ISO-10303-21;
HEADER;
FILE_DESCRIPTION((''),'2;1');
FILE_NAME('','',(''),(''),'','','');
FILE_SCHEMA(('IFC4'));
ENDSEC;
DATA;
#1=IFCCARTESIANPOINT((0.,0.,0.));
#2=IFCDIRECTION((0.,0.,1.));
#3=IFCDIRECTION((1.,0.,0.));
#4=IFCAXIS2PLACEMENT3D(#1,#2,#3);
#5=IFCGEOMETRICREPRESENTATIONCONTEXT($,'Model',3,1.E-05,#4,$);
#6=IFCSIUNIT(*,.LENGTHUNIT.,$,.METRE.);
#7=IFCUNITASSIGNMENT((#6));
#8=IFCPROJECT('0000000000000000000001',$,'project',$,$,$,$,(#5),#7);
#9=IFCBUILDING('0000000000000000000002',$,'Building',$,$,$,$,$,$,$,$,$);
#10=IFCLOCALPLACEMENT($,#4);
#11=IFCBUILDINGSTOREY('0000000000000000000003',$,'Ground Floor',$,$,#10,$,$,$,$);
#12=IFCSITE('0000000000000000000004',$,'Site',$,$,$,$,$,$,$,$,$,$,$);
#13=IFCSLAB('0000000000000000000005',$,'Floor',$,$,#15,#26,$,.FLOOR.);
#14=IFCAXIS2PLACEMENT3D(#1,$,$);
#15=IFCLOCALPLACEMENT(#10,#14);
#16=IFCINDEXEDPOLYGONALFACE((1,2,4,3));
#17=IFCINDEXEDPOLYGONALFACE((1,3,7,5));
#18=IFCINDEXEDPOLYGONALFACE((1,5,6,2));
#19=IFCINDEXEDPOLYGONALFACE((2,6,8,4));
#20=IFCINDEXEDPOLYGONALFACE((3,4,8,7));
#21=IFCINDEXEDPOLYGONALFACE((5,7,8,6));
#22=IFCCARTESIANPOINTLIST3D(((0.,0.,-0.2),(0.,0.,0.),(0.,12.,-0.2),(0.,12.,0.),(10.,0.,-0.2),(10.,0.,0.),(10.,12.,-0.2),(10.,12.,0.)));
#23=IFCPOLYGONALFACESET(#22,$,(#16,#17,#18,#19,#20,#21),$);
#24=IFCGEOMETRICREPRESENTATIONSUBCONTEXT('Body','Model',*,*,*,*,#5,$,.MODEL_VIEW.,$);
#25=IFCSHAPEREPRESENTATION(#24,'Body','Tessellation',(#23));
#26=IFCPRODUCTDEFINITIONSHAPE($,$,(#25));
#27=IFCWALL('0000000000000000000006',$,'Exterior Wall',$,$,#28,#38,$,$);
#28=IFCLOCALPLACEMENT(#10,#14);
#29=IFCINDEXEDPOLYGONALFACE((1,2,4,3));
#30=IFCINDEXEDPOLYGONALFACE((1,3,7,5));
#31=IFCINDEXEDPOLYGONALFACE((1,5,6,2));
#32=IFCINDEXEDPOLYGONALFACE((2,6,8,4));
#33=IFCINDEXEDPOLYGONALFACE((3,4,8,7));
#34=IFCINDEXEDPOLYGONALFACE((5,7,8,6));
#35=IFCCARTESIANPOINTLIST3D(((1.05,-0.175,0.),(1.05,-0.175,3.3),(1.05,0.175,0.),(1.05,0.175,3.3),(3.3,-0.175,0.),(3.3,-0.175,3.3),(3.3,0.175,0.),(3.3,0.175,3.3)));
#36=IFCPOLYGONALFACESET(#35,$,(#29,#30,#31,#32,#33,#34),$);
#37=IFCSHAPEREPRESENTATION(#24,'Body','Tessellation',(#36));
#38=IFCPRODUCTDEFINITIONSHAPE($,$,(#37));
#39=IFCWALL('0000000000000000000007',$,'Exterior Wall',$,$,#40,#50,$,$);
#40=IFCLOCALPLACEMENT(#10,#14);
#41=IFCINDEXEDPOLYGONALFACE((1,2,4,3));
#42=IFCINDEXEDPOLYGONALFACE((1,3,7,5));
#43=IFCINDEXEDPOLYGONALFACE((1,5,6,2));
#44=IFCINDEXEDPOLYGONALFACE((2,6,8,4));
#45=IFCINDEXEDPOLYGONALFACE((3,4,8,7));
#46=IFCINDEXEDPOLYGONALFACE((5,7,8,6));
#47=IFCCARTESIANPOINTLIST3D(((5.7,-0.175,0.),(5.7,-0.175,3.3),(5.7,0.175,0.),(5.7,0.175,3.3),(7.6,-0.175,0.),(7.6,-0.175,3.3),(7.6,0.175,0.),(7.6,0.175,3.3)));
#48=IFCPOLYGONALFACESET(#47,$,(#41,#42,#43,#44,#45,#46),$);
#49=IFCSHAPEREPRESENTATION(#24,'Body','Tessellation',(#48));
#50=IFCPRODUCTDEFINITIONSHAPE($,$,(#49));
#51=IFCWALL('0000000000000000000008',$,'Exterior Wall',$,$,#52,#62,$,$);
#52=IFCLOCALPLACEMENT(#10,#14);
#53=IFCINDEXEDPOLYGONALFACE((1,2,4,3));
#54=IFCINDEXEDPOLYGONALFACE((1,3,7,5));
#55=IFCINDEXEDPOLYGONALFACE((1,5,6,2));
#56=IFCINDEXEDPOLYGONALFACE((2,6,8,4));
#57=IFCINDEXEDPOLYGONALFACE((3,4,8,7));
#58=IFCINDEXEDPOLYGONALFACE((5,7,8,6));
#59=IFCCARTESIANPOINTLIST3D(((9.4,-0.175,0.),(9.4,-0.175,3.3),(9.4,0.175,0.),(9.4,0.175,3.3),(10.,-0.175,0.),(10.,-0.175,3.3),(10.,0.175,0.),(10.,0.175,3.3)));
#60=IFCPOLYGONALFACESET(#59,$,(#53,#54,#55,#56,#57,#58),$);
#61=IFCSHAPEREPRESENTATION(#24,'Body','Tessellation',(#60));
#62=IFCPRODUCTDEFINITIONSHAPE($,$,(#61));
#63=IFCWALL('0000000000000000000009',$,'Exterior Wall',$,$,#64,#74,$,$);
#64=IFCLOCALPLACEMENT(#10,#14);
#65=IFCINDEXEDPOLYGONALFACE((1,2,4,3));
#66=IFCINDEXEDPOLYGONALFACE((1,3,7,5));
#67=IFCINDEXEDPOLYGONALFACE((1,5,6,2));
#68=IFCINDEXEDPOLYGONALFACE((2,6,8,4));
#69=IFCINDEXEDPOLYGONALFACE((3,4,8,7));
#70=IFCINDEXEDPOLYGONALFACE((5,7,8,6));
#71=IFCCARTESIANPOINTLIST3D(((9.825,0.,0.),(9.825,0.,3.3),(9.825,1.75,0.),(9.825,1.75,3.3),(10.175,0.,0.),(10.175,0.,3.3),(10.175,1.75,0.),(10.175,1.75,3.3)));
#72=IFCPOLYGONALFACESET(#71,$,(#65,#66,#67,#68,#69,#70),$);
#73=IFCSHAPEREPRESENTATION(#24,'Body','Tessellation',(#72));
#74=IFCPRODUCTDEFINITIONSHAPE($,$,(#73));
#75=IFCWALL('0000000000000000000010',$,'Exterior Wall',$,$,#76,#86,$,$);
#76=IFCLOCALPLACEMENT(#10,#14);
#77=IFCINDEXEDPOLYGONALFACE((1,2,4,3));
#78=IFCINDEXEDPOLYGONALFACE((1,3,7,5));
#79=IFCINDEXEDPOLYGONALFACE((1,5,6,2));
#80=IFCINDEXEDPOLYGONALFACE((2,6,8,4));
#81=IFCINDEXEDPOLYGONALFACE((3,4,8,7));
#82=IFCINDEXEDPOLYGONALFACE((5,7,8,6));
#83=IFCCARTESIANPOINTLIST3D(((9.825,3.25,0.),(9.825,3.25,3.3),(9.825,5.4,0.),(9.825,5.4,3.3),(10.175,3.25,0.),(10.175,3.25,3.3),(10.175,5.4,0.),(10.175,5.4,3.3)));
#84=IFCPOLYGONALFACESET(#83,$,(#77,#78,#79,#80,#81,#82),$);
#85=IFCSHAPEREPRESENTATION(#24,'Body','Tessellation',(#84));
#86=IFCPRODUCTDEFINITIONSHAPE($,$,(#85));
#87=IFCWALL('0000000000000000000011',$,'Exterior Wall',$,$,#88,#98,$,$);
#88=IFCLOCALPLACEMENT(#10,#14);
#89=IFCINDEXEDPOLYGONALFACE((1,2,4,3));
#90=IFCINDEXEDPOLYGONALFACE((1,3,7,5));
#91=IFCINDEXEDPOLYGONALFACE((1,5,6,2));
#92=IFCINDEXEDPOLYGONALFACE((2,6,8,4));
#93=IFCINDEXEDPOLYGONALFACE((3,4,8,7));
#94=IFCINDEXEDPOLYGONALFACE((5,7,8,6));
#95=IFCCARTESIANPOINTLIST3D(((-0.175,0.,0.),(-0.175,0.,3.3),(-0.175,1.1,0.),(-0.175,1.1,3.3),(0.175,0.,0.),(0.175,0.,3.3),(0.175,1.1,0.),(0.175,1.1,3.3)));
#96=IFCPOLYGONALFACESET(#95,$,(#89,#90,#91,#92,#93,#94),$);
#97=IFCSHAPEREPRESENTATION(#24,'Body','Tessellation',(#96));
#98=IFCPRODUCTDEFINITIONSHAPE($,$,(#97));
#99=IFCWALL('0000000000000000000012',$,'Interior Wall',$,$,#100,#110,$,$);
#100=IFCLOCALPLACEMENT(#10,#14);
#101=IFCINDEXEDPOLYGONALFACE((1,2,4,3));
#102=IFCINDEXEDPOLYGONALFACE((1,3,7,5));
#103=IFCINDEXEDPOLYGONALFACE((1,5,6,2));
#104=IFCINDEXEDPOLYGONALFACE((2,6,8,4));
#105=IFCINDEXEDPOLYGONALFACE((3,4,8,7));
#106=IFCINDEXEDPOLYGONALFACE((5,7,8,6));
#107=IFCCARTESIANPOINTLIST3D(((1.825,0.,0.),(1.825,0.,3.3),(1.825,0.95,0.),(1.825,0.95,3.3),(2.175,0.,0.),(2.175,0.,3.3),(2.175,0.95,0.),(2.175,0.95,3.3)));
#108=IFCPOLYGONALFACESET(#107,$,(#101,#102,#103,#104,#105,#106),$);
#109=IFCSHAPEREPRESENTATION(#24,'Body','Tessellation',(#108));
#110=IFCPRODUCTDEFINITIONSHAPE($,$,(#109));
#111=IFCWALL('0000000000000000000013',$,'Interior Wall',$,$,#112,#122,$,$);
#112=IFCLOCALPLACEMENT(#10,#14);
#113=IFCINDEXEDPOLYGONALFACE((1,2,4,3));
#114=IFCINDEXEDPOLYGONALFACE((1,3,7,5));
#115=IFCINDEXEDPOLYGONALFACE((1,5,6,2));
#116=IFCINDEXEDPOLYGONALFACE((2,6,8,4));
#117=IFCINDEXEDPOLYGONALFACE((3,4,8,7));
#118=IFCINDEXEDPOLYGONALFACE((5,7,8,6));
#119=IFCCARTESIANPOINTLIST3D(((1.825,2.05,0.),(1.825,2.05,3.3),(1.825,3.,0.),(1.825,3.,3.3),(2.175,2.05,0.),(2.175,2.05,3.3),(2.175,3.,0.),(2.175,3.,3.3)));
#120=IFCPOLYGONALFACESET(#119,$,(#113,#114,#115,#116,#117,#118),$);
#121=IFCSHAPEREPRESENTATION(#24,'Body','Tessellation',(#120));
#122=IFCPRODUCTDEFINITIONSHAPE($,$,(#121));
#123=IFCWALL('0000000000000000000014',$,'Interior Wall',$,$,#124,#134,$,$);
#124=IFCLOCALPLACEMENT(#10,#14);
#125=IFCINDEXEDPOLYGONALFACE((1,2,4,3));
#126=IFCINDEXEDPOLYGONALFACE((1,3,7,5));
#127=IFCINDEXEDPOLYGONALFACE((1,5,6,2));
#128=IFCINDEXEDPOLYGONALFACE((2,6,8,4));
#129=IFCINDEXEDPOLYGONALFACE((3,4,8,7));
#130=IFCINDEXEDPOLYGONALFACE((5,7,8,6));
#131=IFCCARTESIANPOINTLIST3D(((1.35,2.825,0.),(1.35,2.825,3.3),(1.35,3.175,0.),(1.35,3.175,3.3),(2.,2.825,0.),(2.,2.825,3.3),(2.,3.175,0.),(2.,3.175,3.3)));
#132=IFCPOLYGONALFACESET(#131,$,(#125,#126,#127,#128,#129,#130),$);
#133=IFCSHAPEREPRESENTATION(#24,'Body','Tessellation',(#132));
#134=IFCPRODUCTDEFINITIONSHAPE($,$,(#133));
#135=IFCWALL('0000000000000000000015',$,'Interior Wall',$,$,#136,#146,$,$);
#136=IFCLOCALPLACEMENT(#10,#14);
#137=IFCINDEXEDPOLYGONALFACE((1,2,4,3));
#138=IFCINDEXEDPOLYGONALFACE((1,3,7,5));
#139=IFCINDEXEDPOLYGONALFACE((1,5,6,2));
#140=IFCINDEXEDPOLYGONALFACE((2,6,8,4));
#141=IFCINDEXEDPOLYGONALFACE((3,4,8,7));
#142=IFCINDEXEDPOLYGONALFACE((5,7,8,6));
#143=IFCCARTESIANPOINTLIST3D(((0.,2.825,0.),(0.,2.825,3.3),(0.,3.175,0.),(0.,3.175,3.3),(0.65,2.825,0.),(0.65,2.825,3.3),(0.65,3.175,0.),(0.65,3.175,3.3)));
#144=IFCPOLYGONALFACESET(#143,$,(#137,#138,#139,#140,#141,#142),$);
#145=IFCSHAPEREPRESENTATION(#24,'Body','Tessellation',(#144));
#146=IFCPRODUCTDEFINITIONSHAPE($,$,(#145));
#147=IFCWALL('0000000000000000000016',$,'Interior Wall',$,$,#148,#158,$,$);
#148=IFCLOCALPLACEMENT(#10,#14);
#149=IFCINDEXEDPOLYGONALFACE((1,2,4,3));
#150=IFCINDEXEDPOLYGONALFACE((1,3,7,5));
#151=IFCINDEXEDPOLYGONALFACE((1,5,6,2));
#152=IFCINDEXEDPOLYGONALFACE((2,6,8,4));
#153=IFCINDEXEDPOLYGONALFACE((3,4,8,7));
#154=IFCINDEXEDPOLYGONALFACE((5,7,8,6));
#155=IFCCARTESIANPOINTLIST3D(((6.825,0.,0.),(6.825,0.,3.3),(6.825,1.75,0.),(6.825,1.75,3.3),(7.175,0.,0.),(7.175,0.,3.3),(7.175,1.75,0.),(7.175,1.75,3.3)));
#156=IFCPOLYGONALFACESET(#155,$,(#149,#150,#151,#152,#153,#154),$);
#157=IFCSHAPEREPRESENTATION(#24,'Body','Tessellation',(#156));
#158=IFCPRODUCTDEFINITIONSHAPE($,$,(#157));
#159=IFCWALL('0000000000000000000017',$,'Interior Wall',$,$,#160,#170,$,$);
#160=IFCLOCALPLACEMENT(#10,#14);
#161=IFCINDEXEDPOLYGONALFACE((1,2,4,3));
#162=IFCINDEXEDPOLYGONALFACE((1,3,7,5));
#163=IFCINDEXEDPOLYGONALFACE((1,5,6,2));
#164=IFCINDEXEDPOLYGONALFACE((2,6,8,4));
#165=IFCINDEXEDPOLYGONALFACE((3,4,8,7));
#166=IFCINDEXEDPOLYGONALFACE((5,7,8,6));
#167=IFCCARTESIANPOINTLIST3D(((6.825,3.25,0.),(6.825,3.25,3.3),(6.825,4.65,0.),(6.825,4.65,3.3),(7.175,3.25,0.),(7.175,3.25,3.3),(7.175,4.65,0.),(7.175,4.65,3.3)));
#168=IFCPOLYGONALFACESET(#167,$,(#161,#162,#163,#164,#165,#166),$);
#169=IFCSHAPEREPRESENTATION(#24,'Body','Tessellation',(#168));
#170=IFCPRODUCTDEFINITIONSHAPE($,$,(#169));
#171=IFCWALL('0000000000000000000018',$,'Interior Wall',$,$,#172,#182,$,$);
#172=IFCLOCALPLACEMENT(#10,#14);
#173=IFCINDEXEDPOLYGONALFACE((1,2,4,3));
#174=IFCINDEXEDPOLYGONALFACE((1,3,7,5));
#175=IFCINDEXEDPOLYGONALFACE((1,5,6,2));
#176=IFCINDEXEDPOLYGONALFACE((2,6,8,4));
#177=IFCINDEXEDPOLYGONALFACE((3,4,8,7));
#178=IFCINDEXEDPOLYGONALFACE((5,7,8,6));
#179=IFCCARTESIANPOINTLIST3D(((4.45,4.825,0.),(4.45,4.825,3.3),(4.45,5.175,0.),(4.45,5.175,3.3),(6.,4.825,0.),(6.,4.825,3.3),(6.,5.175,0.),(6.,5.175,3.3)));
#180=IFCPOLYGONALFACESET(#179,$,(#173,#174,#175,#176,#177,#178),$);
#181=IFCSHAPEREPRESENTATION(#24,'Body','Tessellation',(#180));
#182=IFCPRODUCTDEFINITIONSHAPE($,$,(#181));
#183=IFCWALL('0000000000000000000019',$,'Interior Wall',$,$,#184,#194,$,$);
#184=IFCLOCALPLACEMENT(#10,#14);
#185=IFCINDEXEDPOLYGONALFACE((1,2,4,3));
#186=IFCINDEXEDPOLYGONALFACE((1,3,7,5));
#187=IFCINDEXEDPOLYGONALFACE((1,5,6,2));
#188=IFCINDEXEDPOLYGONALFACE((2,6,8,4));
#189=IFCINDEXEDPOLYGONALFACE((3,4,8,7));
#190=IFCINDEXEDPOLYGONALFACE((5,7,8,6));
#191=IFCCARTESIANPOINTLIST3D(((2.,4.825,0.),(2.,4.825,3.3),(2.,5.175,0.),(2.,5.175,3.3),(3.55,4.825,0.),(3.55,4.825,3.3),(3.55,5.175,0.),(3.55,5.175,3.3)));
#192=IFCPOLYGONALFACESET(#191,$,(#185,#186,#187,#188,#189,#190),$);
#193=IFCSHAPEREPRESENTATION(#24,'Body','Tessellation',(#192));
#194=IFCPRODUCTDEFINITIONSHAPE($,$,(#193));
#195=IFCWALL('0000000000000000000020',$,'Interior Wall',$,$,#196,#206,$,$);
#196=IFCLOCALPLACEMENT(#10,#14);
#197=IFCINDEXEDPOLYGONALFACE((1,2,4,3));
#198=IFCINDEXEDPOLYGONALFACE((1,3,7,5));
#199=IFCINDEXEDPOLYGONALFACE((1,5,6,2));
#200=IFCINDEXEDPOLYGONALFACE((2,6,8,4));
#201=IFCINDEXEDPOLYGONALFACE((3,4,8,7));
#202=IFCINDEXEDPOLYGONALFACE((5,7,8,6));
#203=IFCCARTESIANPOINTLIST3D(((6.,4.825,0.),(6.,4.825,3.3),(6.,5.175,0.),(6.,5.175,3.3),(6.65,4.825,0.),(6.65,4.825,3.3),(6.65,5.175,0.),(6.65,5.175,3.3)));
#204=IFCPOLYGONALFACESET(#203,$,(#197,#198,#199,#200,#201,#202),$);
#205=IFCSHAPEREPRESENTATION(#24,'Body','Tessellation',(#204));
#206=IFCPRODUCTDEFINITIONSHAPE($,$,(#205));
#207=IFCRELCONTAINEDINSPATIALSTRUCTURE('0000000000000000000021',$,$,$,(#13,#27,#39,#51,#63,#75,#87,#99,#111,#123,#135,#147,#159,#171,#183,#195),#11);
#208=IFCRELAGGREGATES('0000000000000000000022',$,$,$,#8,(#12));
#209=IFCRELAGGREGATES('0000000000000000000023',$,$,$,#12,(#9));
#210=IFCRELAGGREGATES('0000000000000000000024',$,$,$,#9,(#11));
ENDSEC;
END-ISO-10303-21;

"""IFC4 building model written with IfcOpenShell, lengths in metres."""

from ifc_helpers import new_model, si_unit, frame, origin_with_axes, place, context, subcontext, project, spatial, indexed_curve, outline, extrude, element, save


model = new_model("IFC4")

# Units and contexts
model_context = context("Model", 3, precision=1e-05, world=origin_with_axes())
body_context = subcontext(model_context, "Body", "Model", "MODEL_VIEW")
ifc_project = project(units=[si_unit("LENGTHUNIT", "METRE")], contexts=[model_context])

# Site, building, storey
site = spatial("IfcSite", under=ifc_project, Name="Site")
building = spatial("IfcBuilding", under=site, Name="Building")
storey_placement = place(None, origin_with_axes())
storey = spatial("IfcBuildingStorey", under=building, at=storey_placement, Name="Ground Floor")

# Slab
slab_placement = place(storey_placement, frame((0.0, 0.0, -0.2), z_axis=(0.0, 0.0, 1.0), x_axis=(1.0, 0.0, 0.0)))
element("IfcSlab", 1, at=slab_placement, inside=storey, Name="Floor", PredefinedType="FLOOR", context=body_context, shape_type="SweptSolid", body=[
    extrude(outline(indexed_curve([(0.0, 0.0), (10.0, 0.0), (10.0, 12.0), (0.0, 12.0)])), None, (0.0, 0.0, 1.0), 0.2),
])

# Walls
wall_1_placement = place(storey_placement, frame((1.05, 0.0, 0.0), z_axis=(0.0, 0.0, 1.0), x_axis=(1.0, 0.0, 0.0)))
element("IfcWall", 2, at=wall_1_placement, inside=storey, Name="Exterior Wall", context=body_context, shape_type="SweptSolid", body=[
    extrude(outline(indexed_curve([(0.0, 0.0), (0.0, 0.35), (2.25, 0.35), (2.25, 0.0), (0.0, 0.0)], self_intersect=False)), frame((0.0, -0.175, 0.0), z_axis=(0.0, 0.0, 1.0), x_axis=(1.0, 0.0, 0.0)), (0.0, 0.0, 1.0), 3.3),
])
wall_2_placement = place(storey_placement, frame((5.7, 0.0, 0.0), z_axis=(0.0, 0.0, 1.0), x_axis=(1.0, 0.0, 0.0)))
element("IfcWall", 3, at=wall_2_placement, inside=storey, Name="Exterior Wall", context=body_context, shape_type="SweptSolid", body=[
    extrude(outline(indexed_curve([(0.0, 0.0), (0.0, 0.35), (1.9, 0.35), (1.9, 0.0), (0.0, 0.0)], self_intersect=False)), frame((0.0, -0.175, 0.0), z_axis=(0.0, 0.0, 1.0), x_axis=(1.0, 0.0, 0.0)), (0.0, 0.0, 1.0), 3.3),
])
wall_3_placement = place(storey_placement, frame((9.4, 0.0, 0.0), z_axis=(0.0, 0.0, 1.0), x_axis=(1.0, 0.0, 0.0)))
element("IfcWall", 4, at=wall_3_placement, inside=storey, Name="Exterior Wall", context=body_context, shape_type="SweptSolid", body=[
    extrude(outline(indexed_curve([(0.0, 0.0), (0.0, 0.35), (0.6, 0.35), (0.6, 0.0), (0.0, 0.0)], self_intersect=False)), frame((0.0, -0.175, 0.0), z_axis=(0.0, 0.0, 1.0), x_axis=(1.0, 0.0, 0.0)), (0.0, 0.0, 1.0), 3.3),
])
wall_4_placement = place(storey_placement, frame((10.0, 0.0, 0.0), z_axis=(0.0, 0.0, 1.0), x_axis=(0.0, 1.0, 0.0)))
element("IfcWall", 5, at=wall_4_placement, inside=storey, Name="Exterior Wall", context=body_context, shape_type="SweptSolid", body=[
    extrude(outline(indexed_curve([(0.0, 0.0), (0.0, 0.35), (1.75, 0.35), (1.75, 0.0), (0.0, 0.0)], self_intersect=False)), frame((0.0, -0.175, 0.0), z_axis=(0.0, 0.0, 1.0), x_axis=(1.0, 0.0, 0.0)), (0.0, 0.0, 1.0), 3.3),
])
wall_5_placement = place(storey_placement, frame((10.0, 3.25, 0.0), z_axis=(0.0, 0.0, 1.0), x_axis=(0.0, 1.0, 0.0)))
element("IfcWall", 6, at=wall_5_placement, inside=storey, Name="Exterior Wall", context=body_context, shape_type="SweptSolid", body=[
    extrude(outline(indexed_curve([(0.0, 0.0), (0.0, 0.35), (2.15, 0.35), (2.15, 0.0), (0.0, 0.0)], self_intersect=False)), frame((0.0, -0.175, 0.0), z_axis=(0.0, 0.0, 1.0), x_axis=(1.0, 0.0, 0.0)), (0.0, 0.0, 1.0), 3.3),
])
wall_6_placement = place(storey_placement, frame((0.0, 1.1, 0.0), z_axis=(0.0, 0.0, 1.0), x_axis=(0.0, -1.0, 0.0)))
element("IfcWall", 7, at=wall_6_placement, inside=storey, Name="Exterior Wall", context=body_context, shape_type="SweptSolid", body=[
    extrude(outline(indexed_curve([(0.0, 0.0), (0.0, 0.35), (1.1, 0.35), (1.1, 0.0), (0.0, 0.0)], self_intersect=False)), frame((0.0, -0.175, 0.0), z_axis=(0.0, 0.0, 1.0), x_axis=(1.0, 0.0, 0.0)), (0.0, 0.0, 1.0), 3.3),
])
wall_7_placement = place(storey_placement, frame((2.0, 0.0, 0.0), z_axis=(0.0, 0.0, 1.0), x_axis=(0.0, 1.0, 0.0)))
element("IfcWall", 8, at=wall_7_placement, inside=storey, Name="Interior Wall", context=body_context, shape_type="SweptSolid", body=[
    extrude(outline(indexed_curve([(0.0, 0.0), (0.0, 0.35), (0.95, 0.35), (0.95, 0.0), (0.0, 0.0)], self_intersect=False)), frame((0.0, -0.175, 0.0), z_axis=(0.0, 0.0, 1.0), x_axis=(1.0, 0.0, 0.0)), (0.0, 0.0, 1.0), 3.3),
])
wall_8_placement = place(storey_placement, frame((2.0, 2.05, 0.0), z_axis=(0.0, 0.0, 1.0), x_axis=(0.0, 1.0, 0.0)))
element("IfcWall", 9, at=wall_8_placement, inside=storey, Name="Interior Wall", context=body_context, shape_type="SweptSolid", body=[
    extrude(outline(indexed_curve([(0.0, 0.0), (0.0, 0.35), (0.95, 0.35), (0.95, 0.0), (0.0, 0.0)], self_intersect=False)), frame((0.0, -0.175, 0.0), z_axis=(0.0, 0.0, 1.0), x_axis=(1.0, 0.0, 0.0)), (0.0, 0.0, 1.0), 3.3),
])
for number, where, z_axis, x_axis, name in (
    (10, (2.0, 3.0, 0.0), (0.0, 0.0, 1.0), (-1.0, 0.0, 0.0), "Interior Wall"),
    (11, (0.65, 3.0, 0.0), (0.0, 0.0, 1.0), (-1.0, 0.0, 0.0), "Interior Wall"),
):
    element("IfcWall", number, at=place(storey_placement, frame(where, z_axis=z_axis, x_axis=x_axis)), inside=storey, Name=name, context=body_context, shape_type="SweptSolid", body=[
        extrude(outline(indexed_curve([(0.0, 0.0), (0.0, 0.35), (0.65, 0.35), (0.65, 0.0), (0.0, 0.0)], self_intersect=False)), frame((0.0, -0.175, 0.0), z_axis=(0.0, 0.0, 1.0), x_axis=(1.0, 0.0, 0.0)), (0.0, 0.0, 1.0), 3.3),
    ])
wall_9_placement = place(storey_placement, frame((7.0, 0.0, 0.0), z_axis=(0.0, 0.0, 1.0), x_axis=(0.0, 1.0, 0.0)))
element("IfcWall", 12, at=wall_9_placement, inside=storey, Name="Interior Wall", context=body_context, shape_type="SweptSolid", body=[
    extrude(outline(indexed_curve([(0.0, 0.0), (0.0, 0.35), (1.75, 0.35), (1.75, 0.0), (0.0, 0.0)], self_intersect=False)), frame((0.0, -0.175, 0.0), z_axis=(0.0, 0.0, 1.0), x_axis=(1.0, 0.0, 0.0)), (0.0, 0.0, 1.0), 3.3),
])
wall_10_placement = place(storey_placement, frame((7.0, 3.25, 0.0), z_axis=(0.0, 0.0, 1.0), x_axis=(0.0, 1.0, 0.0)))
element("IfcWall", 13, at=wall_10_placement, inside=storey, Name="Interior Wall", context=body_context, shape_type="SweptSolid", body=[
    extrude(outline(indexed_curve([(0.0, 0.0), (0.0, 0.35), (1.4, 0.35), (1.4, 0.0), (0.0, 0.0)], self_intersect=False)), frame((0.0, -0.175, 0.0), z_axis=(0.0, 0.0, 1.0), x_axis=(1.0, 0.0, 0.0)), (0.0, 0.0, 1.0), 3.3),
])
for number, where, z_axis, x_axis, name in (
    (14, (6.0, 5.0, 0.0), (0.0, 0.0, 1.0), (-1.0, 0.0, 0.0), "Interior Wall"),
    (15, (3.55, 5.0, 0.0), (0.0, 0.0, 1.0), (-1.0, 0.0, 0.0), "Interior Wall"),
):
    element("IfcWall", number, at=place(storey_placement, frame(where, z_axis=z_axis, x_axis=x_axis)), inside=storey, Name=name, context=body_context, shape_type="SweptSolid", body=[
        extrude(outline(indexed_curve([(0.0, 0.0), (0.0, 0.35), (1.55, 0.35), (1.55, 0.0), (0.0, 0.0)], self_intersect=False)), frame((0.0, -0.175, 0.0), z_axis=(0.0, 0.0, 1.0), x_axis=(1.0, 0.0, 0.0)), (0.0, 0.0, 1.0), 3.3),
    ])
wall_11_placement = place(storey_placement, frame((6.65, 5.0, 0.0), z_axis=(0.0, 0.0, 1.0), x_axis=(-1.0, 0.0, 0.0)))
element("IfcWall", 16, at=wall_11_placement, inside=storey, Name="Interior Wall", context=body_context, shape_type="SweptSolid", body=[
    extrude(outline(indexed_curve([(0.0, 0.0), (0.0, 0.35), (0.65, 0.35), (0.65, 0.0), (0.0, 0.0)], self_intersect=False)), frame((0.0, -0.175, 0.0), z_axis=(0.0, 0.0, 1.0), x_axis=(1.0, 0.0, 0.0)), (0.0, 0.0, 1.0), 3.3),
])

save(model, "model.ifc")
